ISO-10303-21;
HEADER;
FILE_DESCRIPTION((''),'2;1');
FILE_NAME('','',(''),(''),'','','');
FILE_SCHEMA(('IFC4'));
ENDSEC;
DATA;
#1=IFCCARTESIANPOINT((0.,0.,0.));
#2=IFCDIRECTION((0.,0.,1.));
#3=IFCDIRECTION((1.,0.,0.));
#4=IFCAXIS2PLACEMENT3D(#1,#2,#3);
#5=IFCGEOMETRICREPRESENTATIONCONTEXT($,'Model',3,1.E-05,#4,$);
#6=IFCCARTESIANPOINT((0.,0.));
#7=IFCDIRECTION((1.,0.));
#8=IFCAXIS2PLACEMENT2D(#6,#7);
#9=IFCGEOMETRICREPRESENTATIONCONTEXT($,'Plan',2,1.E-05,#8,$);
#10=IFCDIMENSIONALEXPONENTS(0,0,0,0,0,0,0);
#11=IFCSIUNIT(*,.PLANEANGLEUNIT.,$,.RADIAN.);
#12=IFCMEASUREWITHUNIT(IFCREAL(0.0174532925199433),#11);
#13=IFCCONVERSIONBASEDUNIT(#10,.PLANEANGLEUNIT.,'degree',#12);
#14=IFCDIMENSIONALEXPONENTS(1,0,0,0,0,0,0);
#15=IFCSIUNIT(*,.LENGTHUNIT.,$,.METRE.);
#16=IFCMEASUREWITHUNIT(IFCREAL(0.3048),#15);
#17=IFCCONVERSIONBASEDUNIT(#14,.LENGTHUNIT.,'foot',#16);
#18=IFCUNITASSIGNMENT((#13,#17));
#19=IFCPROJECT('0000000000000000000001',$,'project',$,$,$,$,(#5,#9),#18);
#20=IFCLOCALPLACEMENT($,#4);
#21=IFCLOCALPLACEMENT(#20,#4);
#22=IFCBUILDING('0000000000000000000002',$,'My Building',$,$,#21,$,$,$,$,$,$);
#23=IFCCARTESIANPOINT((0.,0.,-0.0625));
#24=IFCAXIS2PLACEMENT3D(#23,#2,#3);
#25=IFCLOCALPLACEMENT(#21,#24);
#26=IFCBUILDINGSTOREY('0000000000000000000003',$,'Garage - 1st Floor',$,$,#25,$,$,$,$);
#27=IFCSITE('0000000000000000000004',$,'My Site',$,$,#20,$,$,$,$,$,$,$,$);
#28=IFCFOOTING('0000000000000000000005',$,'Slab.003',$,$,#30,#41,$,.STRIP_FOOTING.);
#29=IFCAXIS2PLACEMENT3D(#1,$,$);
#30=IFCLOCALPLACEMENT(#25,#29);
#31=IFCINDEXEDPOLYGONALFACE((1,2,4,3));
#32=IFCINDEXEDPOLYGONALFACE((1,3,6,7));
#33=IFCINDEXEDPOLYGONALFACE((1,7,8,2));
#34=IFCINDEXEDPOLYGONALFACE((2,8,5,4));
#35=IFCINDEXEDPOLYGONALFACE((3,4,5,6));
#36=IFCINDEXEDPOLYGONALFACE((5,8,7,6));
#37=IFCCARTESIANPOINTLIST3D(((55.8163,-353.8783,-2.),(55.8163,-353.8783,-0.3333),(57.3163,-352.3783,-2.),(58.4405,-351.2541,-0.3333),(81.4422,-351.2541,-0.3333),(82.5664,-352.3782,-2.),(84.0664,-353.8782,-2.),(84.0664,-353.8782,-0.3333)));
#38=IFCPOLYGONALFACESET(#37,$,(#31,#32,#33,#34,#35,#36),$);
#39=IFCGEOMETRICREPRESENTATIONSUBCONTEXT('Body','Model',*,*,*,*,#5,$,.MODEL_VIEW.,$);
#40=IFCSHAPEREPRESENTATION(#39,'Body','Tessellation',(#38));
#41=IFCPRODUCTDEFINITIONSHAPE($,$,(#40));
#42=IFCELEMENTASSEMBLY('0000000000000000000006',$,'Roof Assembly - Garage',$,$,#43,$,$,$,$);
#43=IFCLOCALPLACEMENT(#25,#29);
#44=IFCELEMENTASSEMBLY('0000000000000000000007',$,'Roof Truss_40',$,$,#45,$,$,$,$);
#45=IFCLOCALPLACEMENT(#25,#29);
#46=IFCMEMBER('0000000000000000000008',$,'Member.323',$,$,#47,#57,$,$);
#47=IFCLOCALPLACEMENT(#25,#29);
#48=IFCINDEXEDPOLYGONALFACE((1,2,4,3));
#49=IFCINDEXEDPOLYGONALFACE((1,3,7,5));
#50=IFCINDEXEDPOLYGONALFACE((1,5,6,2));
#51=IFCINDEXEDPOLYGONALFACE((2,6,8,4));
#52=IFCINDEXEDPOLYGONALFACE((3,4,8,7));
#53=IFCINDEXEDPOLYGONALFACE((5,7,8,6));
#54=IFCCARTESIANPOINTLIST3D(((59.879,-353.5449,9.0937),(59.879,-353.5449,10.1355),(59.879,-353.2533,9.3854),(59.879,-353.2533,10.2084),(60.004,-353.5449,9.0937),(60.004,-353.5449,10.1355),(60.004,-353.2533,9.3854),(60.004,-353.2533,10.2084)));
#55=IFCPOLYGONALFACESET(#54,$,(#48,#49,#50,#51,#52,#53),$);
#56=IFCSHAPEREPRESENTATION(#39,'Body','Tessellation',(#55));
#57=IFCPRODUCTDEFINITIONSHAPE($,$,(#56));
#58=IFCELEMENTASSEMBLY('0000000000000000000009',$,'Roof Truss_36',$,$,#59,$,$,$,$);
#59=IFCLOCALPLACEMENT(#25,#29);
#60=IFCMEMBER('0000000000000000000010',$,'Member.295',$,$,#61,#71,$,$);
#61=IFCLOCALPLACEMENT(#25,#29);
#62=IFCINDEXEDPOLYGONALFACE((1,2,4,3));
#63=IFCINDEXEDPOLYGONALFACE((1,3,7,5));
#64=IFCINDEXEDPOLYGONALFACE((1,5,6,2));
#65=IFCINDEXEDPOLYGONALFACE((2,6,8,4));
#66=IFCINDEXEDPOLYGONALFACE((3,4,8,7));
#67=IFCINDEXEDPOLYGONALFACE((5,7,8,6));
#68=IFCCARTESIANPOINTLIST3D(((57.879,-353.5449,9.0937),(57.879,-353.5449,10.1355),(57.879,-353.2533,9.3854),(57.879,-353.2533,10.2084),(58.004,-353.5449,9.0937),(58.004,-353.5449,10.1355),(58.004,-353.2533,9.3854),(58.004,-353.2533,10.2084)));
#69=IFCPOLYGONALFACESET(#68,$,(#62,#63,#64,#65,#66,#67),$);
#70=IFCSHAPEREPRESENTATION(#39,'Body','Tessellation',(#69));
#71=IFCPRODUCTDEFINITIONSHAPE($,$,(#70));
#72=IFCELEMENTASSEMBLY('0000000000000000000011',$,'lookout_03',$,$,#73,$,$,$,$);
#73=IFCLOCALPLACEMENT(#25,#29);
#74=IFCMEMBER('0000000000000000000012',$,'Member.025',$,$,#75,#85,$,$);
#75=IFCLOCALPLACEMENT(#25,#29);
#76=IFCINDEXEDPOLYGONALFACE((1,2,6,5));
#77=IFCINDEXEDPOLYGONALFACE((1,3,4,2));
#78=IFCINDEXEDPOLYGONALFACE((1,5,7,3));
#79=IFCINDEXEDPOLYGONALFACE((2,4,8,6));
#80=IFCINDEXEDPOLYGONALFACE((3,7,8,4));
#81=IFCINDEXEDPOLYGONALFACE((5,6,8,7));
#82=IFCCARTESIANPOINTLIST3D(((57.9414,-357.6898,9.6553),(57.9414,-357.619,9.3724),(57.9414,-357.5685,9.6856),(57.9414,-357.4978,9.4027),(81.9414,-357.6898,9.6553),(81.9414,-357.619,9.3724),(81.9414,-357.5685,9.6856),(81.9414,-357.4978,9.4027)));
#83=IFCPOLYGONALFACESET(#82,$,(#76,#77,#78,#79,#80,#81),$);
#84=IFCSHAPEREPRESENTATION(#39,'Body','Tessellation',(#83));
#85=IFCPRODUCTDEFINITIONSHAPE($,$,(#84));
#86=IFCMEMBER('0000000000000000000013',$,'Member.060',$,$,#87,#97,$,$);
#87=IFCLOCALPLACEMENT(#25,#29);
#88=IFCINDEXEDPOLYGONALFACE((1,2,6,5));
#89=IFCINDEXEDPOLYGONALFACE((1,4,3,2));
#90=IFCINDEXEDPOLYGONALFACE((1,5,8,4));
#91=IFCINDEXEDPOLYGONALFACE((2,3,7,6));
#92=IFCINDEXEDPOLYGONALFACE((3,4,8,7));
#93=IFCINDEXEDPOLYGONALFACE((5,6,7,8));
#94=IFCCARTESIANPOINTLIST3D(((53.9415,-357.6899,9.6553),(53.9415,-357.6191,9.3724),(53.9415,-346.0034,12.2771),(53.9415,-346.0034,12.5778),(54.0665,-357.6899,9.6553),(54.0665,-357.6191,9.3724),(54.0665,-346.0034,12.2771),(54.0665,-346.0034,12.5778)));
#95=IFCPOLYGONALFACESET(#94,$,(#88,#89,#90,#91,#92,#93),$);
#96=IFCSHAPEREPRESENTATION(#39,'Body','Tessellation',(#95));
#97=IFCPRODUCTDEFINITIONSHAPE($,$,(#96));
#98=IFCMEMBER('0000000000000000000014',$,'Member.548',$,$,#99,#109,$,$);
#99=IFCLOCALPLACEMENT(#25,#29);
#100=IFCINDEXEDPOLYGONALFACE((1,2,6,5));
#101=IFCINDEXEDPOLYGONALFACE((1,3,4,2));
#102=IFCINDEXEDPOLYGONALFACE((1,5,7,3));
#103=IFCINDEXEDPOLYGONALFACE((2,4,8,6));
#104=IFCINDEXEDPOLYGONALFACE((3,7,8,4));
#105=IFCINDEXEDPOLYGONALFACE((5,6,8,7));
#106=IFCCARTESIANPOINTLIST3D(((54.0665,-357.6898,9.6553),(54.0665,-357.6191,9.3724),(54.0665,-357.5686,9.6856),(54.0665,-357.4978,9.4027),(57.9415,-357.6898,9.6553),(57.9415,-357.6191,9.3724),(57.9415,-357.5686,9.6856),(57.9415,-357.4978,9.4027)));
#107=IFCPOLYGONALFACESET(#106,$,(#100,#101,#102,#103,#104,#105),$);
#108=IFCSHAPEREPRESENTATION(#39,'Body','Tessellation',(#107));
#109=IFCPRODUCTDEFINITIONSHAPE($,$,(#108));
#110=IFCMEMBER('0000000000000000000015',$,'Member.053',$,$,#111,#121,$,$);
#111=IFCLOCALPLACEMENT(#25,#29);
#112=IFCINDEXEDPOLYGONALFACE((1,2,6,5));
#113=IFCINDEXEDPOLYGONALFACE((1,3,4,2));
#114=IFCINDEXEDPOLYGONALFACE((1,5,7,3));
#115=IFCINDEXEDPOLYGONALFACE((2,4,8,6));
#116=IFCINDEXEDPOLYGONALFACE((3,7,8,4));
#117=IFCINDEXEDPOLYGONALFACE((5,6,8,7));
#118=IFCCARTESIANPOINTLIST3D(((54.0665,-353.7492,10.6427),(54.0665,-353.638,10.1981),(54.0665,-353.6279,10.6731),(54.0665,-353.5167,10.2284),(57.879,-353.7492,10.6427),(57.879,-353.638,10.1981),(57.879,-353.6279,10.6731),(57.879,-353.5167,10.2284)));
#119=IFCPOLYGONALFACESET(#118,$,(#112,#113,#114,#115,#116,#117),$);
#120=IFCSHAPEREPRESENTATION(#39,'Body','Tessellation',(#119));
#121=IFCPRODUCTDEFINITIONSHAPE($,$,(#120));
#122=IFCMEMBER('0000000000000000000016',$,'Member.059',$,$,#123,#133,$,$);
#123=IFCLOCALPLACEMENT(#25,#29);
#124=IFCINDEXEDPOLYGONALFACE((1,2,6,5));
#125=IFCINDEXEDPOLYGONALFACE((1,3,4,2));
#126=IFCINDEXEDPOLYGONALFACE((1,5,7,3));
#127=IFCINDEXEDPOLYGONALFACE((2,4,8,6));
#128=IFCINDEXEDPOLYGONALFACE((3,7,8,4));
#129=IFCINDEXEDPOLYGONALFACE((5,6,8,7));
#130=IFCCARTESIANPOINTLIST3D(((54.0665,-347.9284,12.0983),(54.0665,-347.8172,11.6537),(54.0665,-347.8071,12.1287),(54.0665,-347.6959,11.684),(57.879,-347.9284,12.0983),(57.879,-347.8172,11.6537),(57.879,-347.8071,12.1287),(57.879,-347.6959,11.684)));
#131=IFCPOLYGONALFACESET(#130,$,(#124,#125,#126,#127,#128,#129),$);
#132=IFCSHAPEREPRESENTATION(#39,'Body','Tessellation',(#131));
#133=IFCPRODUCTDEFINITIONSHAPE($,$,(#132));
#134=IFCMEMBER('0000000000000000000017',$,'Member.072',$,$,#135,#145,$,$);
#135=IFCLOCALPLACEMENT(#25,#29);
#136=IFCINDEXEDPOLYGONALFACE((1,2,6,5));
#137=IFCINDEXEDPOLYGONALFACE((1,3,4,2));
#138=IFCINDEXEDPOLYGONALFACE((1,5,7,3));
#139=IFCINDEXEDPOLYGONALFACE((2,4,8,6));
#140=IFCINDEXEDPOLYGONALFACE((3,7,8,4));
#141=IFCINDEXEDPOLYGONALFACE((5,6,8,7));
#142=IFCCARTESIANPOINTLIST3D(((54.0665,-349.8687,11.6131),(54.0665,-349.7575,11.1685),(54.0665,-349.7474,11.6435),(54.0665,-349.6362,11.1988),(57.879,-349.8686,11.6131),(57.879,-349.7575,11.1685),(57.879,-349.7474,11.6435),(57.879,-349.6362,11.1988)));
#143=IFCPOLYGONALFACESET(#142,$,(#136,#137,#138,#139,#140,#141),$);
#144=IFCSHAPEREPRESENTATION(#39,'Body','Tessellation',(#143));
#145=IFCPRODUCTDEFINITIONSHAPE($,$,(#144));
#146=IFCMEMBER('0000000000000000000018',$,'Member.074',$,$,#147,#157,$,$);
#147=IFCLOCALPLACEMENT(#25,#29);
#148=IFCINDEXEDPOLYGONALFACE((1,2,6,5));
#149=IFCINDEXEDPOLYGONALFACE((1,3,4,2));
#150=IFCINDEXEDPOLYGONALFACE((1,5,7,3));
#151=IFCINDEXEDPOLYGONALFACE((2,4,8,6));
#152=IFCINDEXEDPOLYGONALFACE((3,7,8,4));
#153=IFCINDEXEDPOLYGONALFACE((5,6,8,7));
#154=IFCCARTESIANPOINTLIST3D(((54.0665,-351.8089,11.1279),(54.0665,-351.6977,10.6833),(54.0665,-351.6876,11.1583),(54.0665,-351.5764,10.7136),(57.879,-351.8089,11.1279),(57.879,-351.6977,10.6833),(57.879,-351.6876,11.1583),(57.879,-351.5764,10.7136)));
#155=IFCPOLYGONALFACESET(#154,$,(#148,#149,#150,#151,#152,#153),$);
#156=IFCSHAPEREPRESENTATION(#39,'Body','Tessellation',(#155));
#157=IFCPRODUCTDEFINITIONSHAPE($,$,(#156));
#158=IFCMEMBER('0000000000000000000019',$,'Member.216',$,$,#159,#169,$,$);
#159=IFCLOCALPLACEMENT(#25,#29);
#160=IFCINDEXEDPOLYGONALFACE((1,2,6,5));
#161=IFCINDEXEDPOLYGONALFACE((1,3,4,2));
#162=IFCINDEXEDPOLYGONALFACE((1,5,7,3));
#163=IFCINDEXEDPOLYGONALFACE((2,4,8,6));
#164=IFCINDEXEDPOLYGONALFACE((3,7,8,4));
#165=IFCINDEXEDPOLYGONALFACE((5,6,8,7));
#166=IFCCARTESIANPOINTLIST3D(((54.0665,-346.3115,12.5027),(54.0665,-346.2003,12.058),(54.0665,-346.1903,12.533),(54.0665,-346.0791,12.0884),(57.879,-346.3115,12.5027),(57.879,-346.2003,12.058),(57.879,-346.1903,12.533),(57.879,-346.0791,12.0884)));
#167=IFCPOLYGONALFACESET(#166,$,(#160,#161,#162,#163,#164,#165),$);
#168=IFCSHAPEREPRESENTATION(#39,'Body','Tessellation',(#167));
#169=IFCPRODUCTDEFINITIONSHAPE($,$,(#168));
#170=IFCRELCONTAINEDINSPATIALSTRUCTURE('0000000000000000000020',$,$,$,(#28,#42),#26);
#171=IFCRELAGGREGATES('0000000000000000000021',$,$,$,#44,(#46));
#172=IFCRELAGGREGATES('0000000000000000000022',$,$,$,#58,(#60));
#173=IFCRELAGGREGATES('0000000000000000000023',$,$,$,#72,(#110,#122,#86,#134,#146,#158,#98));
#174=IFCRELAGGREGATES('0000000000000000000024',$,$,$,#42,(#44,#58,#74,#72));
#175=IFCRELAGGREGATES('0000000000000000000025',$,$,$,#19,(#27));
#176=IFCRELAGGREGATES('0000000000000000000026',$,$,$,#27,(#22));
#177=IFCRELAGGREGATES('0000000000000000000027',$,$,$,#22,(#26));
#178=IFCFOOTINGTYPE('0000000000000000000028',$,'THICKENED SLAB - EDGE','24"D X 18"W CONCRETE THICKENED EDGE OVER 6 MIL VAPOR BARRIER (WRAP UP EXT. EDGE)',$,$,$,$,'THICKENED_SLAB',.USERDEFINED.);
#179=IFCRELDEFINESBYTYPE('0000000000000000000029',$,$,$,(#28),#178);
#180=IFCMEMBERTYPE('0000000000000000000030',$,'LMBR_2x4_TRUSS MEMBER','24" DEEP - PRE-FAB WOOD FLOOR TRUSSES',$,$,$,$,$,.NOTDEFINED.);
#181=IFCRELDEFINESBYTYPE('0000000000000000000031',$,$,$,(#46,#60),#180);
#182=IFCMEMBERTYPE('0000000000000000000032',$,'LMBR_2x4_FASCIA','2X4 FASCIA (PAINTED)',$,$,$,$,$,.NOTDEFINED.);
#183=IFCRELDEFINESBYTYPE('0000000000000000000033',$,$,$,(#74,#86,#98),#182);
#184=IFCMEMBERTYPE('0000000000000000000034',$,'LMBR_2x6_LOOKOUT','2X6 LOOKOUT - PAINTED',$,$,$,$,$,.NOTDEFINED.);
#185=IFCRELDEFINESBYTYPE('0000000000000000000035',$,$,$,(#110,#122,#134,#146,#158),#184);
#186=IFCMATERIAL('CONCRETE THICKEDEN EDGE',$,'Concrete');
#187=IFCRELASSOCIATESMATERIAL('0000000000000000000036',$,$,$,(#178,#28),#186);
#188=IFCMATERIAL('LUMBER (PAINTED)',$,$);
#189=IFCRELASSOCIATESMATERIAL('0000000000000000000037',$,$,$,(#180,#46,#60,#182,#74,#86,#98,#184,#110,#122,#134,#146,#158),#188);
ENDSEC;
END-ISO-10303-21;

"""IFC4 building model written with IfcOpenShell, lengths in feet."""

from ifc_helpers import new_model, entity, si_unit, converted_unit, frame, origin_with_axes, origin_2d_with_axis, place, context, subcontext, project, spatial, line, indexed_curve, outline, extrude, clip, halfspace, material, material_profile, profile_set, profile_usage, type_object, element, aggregate, save


model = new_model("IFC4")

# Units and contexts
model_context = context("Model", 3, precision=1e-05, world=origin_with_axes())
plan_context = context("Plan", 2, precision=1e-05, world=origin_2d_with_axis())
body_context = subcontext(model_context, "Body", "Model", "MODEL_VIEW")
ifc_project = project(units=[converted_unit("PLANEANGLEUNIT", "degree", entity("IfcReal", 0.0174532925199433), si_unit("PLANEANGLEUNIT", "RADIAN"), dimensions=[0, 0, 0, 0, 0, 0, 0]), converted_unit("LENGTHUNIT", "foot", entity("IfcReal", 0.3048), si_unit("LENGTHUNIT", "METRE"), dimensions=[1, 0, 0, 0, 0, 0, 0])], contexts=[model_context, plan_context])

# Site, building, storey
site_placement = place(None, origin_with_axes())
site = spatial("IfcSite", under=ifc_project, at=site_placement, Name="My Site")
building_placement = place(site_placement, origin_with_axes())
building = spatial("IfcBuilding", under=site, at=building_placement, Name="My Building")
storey_placement = place(building_placement, frame((0.0, 0.0, -0.0625), z_axis=(0.0, 0.0, 1.0), x_axis=(1.0, 0.0, 0.0)))
storey = spatial("IfcBuildingStorey", under=building, at=storey_placement, Name="Garage - 1st Floor")

# Footing
ifc_material_1 = material(Name="CONCRETE THICKEDEN EDGE", Category="Concrete")
ifc_material_profile_1 = material_profile(ifc_material_1, outline(indexed_curve([(0.0, 1.6667), (0.0, 0.0), (2.6242, 1.6667), (1.5, 0.0)], segments=[line(4, 2), line(2, 1), line(1, 3), line(3, 4)], self_intersect=False)))
ifc_profile_set_1 = profile_set([ifc_material_profile_1])
ifc_profile_usage_1 = profile_usage(ifc_profile_set_1, cardinal=5)
footing_type = type_object("IfcFootingType", Name="THICKENED SLAB - EDGE", Description="24\"D X 18\"W CONCRETE THICKENED EDGE OVER 6 MIL VAPOR BARRIER (WRAP UP EXT. EDGE)", ElementType="THICKENED_SLAB", PredefinedType="USERDEFINED", material=ifc_profile_set_1)
footing_placement = place(storey_placement, frame((55.8163, -353.8783, -2.0), z_axis=(1.0, 0.000001, 0.0), x_axis=(-0.000001, 1.0, 0.0)))
element("IfcFooting", 1, at=footing_placement, inside=storey, type_object=footing_type, material=ifc_profile_usage_1, Name="Slab.003", PredefinedType="STRIP_FOOTING", context=body_context, shape_type="Clipping", body=[
    clip(clip(extrude(outline(indexed_curve([(0.0, 1.6667), (0.0, 0.0), (2.6242, 1.6667), (1.5, 0.0)], segments=[line(4, 2), line(2, 1), line(1, 3), line(3, 4)], self_intersect=False)), origin_with_axes(), (0.0, 0.0, 1.0), 28.2501), halfspace(frame((0.0, 2.0625, 0.0), z_axis=(0.707106, 0.0, -0.707107), x_axis=(0.0, -1.0, 0.0)), False)), halfspace(frame((0.0, 2.0625, 28.2501), z_axis=(0.707106, 0.0, 0.707107), x_axis=(0.0, -1.0, 0.0)), False)),
])

# Element assemblies, members
assembly_1_placement = place(storey_placement, frame((0.0, 0.0, 0.125), z_axis=(0.0, 0.0, 1.0), x_axis=(1.0, 0.0, 0.0)))
assembly_1 = element("IfcElementAssembly", 2, at=assembly_1_placement, inside=storey, Name="Roof Assembly - Garage")
assembly_2_placement = place(assembly_1_placement, frame((59.9415, -346.0033, 12.5192), z_axis=(0.0, 0.0, 1.0), x_axis=(0.0, 1.0, 0.0)))
assembly_2 = element("IfcElementAssembly", 3, at=assembly_2_placement, Name="Roof Truss_40")
ifc_material_2 = material(Name="LUMBER (PAINTED)")
ifc_material_profile_2 = material_profile(ifc_material_2, outline(indexed_curve([(-0.0625, -0.1458), (0.0625, -0.1458), (0.0625, 0.1458), (-0.0625, 0.1458), (-0.0625, -0.1458)])))
ifc_profile_set_2 = profile_set([ifc_material_profile_2])
ifc_profile_usage_2 = profile_usage(ifc_profile_set_2)
member_type_1 = type_object("IfcMemberType", Name="LMBR_2x4_TRUSS MEMBER", Description="24\" DEEP - PRE-FAB WOOD FLOOR TRUSSES", PredefinedType="NOTDEFINED", material=ifc_profile_set_2)
member_1_placement = place(assembly_2_placement, frame((-7.3958, 0.0, -2.1806), z_axis=(0.0, 0.0, -1.0), x_axis=(0.0, 1.0, 0.0)))
member_1 = element("IfcMember", 4, at=member_1_placement, type_object=member_type_1, material=ifc_profile_usage_2, Name="Member.323", context=body_context, shape_type="Clipping", body=[
    clip(clip(extrude(outline(indexed_curve([(-0.0625, -0.1458), (0.0625, -0.1458), (0.0625, 0.1458), (-0.0625, 0.1458), (-0.0625, -0.1458)])), origin_with_axes(), (0.0, 0.0, 1.0), 1.3698), halfspace(frame((0.0, 7.5424, -1.5944), z_axis=(0.0, -0.242599, -0.970127), x_axis=(-1.0, 0.000001, 0.0)), False)), halfspace(frame((397.5032, -0.1458, 1.3698), z_axis=(0.0, 0.707107, 0.707107), x_axis=(1.0, 0.0, 0.0)), False)),
])
assembly_3_placement = place(assembly_1_placement, frame((57.9415, -346.0033, 12.5192), z_axis=(0.0, 0.0, 1.0), x_axis=(0.0, 1.0, 0.0)))
assembly_3 = element("IfcElementAssembly", 5, at=assembly_3_placement, Name="Roof Truss_36")
ifc_profile_usage_3 = profile_usage(ifc_profile_set_2)
member_2_placement = place(assembly_3_placement, frame((-7.3958, 0.0, -2.1806), z_axis=(0.0, 0.0, -1.0), x_axis=(0.0, 1.0, 0.0)))
member_2 = element("IfcMember", 6, at=member_2_placement, type_object=member_type_1, material=ifc_profile_usage_3, Name="Member.295", context=body_context, shape_type="Clipping", body=[
    clip(clip(extrude(outline(indexed_curve([(-0.0625, -0.1458), (0.0625, -0.1458), (0.0625, 0.1458), (-0.0625, 0.1458), (-0.0625, -0.1458)])), origin_with_axes(), (0.0, 0.0, 1.0), 1.3698), halfspace(frame((0.0, 7.5424, -1.5944), z_axis=(0.0, -0.242599, -0.970127), x_axis=(-1.0, 0.000001, 0.0)), False)), halfspace(frame((397.5032, -0.1458, 1.3698), z_axis=(0.0, 0.707107, 0.707107), x_axis=(1.0, 0.0, 0.0)), False)),
])
assembly_4_placement = place(assembly_1_placement, frame((57.9415, -346.0033, 12.5192), z_axis=(0.0, 0.0, 1.0), x_axis=(-0.000001, 1.0, 0.0)))
assembly_4 = element("IfcElementAssembly", 7, at=assembly_4_placement, Name="lookout_03")
aggregate(assembly_2, [member_1])
aggregate(assembly_3, [member_2])
ifc_material_profile_3 = material_profile(ifc_material_2, outline(indexed_curve([(-0.0625, -0.1458), (0.0625, -0.1458), (0.0625, 0.1458), (-0.0625, 0.1458), (-0.0625, -0.1458)])))
ifc_profile_set_3 = profile_set([ifc_material_profile_3])
ifc_profile_usage_4 = profile_usage(ifc_profile_set_3)
member_type_2 = type_object("IfcMemberType", Name="LMBR_2x4_FASCIA", Description="2X4 FASCIA (PAINTED)", PredefinedType="NOTDEFINED", material=ifc_profile_set_3)
member_3_placement = place(assembly_1_placement, frame((57.9414, -357.5938, 9.404), z_axis=(1.0, 0.0, 0.0), x_axis=(-0.000001, 0.970127, 0.242599)))
member_3 = element("IfcMember", 8, at=member_3_placement, type_object=member_type_2, material=ifc_profile_usage_4, Name="Member.025", context=body_context, shape_type="SweptSolid", body=[
    extrude(outline(indexed_curve([(-0.0625, -0.1458), (0.0625, -0.1458), (0.0625, 0.1458), (-0.0625, 0.1458), (-0.0625, -0.1458)])), origin_with_axes(), (0.0, 0.0, 1.0), 24.0),
])
ifc_profile_usage_5 = profile_usage(ifc_profile_set_3)
member_4_placement = place(assembly_4_placement, frame((-11.6512, 3.9375, -3.1303), z_axis=(0.970127, 0.0, 0.242599), x_axis=(0.0, 1.0, 0.0)))
member_4 = element("IfcMember", 9, at=member_4_placement, type_object=member_type_2, material=ifc_profile_usage_5, Name="Member.060", context=body_context, shape_type="Clipping", body=[
    clip(extrude(outline(indexed_curve([(-0.0625, -0.1458), (0.0625, -0.1458), (0.0625, 0.1458), (-0.0625, 0.1458), (-0.0625, -0.1458)])), origin_with_axes(), (0.0, 0.0, 1.0), 12.6114), halfspace(frame((-85.8788, 0.1458, 12.0464), z_axis=(0.0, -0.242599, 0.970127), x_axis=(-1.0, -0.000001, 0.0)), False)),
])
ifc_profile_usage_6 = profile_usage(ifc_profile_set_3)
member_5_placement = place(assembly_4_placement, frame((-11.5905, 0.0, -3.1152), z_axis=(0.0, 1.0, 0.0), x_axis=(-0.970127, 0.0, -0.242599)))
member_5 = element("IfcMember", 10, at=member_5_placement, type_object=member_type_2, material=ifc_profile_usage_6, Name="Member.548", context=body_context, shape_type="SweptSolid", body=[
    extrude(outline(indexed_curve([(-0.0625, -0.1458), (0.0625, -0.1458), (0.0625, 0.1458), (-0.0625, 0.1458), (-0.0625, -0.1458)])), origin_with_axes(), (0.0, 0.0, 1.0), 3.875),
])
ifc_material_profile_4 = material_profile(ifc_material_2, outline(indexed_curve([(-0.0625, 0.2292), (0.0625, 0.2292), (0.0625, -0.2292), (-0.0625, -0.2292), (-0.0625, 0.2292)])))
ifc_profile_set_4 = profile_set([ifc_material_profile_4])
ifc_profile_usage_7 = profile_usage(ifc_profile_set_4)
member_type_3 = type_object("IfcMemberType", Name="LMBR_2x6_LOOKOUT", Description="2X6 LOOKOUT - PAINTED", PredefinedType="NOTDEFINED", material=ifc_profile_set_4)
member_6_placement = place(assembly_4_placement, frame((-7.6296, 0.0625, -2.2086), z_axis=(0.0, 1.0, 0.0), x_axis=(-0.970127, 0.0, -0.242599)))
member_6 = element("IfcMember", 11, at=member_6_placement, type_object=member_type_3, material=ifc_profile_usage_7, Name="Member.053", context=body_context, shape_type="SweptSolid", body=[
    extrude(outline(indexed_curve([(-0.0625, 0.2292), (0.0625, 0.2292), (0.0625, -0.2292), (-0.0625, -0.2292), (-0.0625, 0.2292)])), origin_with_axes(), (0.0, 0.0, 1.0), 3.8125),
])
ifc_profile_usage_8 = profile_usage(ifc_profile_set_4)
member_7_placement = place(assembly_4_placement, frame((-1.8089, 0.0625, -0.753), z_axis=(0.0, 1.0, 0.0), x_axis=(-0.970127, 0.0, -0.242599)))
member_7 = element("IfcMember", 12, at=member_7_placement, type_object=member_type_3, material=ifc_profile_usage_8, Name="Member.059", context=body_context, shape_type="SweptSolid", body=[
    extrude(outline(indexed_curve([(-0.0625, 0.2292), (0.0625, 0.2292), (0.0625, -0.2292), (-0.0625, -0.2292), (-0.0625, 0.2292)])), origin_with_axes(), (0.0, 0.0, 1.0), 3.8125),
])
ifc_profile_usage_9 = profile_usage(ifc_profile_set_4)
member_8_placement = place(assembly_4_placement, frame((-3.7491, 0.0625, -1.2382), z_axis=(0.0, 1.0, 0.0), x_axis=(-0.970127, 0.0, -0.242599)))
member_8 = element("IfcMember", 13, at=member_8_placement, type_object=member_type_3, material=ifc_profile_usage_9, Name="Member.072", context=body_context, shape_type="SweptSolid", body=[
    extrude(outline(indexed_curve([(-0.0625, 0.2292), (0.0625, 0.2292), (0.0625, -0.2292), (-0.0625, -0.2292), (-0.0625, 0.2292)])), origin_with_axes(), (0.0, 0.0, 1.0), 3.8125),
])
ifc_profile_usage_10 = profile_usage(ifc_profile_set_4)
member_9_placement = place(assembly_4_placement, frame((-5.6894, 0.0625, -1.7234), z_axis=(0.0, 1.0, 0.0), x_axis=(-0.970127, 0.0, -0.242599)))
member_9 = element("IfcMember", 14, at=member_9_placement, type_object=member_type_3, material=ifc_profile_usage_10, Name="Member.074", context=body_context, shape_type="SweptSolid", body=[
    extrude(outline(indexed_curve([(-0.0625, 0.2292), (0.0625, 0.2292), (0.0625, -0.2292), (-0.0625, -0.2292), (-0.0625, 0.2292)])), origin_with_axes(), (0.0, 0.0, 1.0), 3.8125),
])
ifc_profile_usage_11 = profile_usage(ifc_profile_set_4)
member_10_placement = place(assembly_4_placement, frame((-0.192, 0.0625, -0.3487), z_axis=(0.0, 1.0, 0.0), x_axis=(-0.970127, 0.0, -0.242599)))
member_10 = element("IfcMember", 15, at=member_10_placement, type_object=member_type_3, material=ifc_profile_usage_11, Name="Member.216", context=body_context, shape_type="SweptSolid", body=[
    extrude(outline(indexed_curve([(-0.0625, 0.2292), (0.0625, 0.2292), (0.0625, -0.2292), (-0.0625, -0.2292), (-0.0625, 0.2292)])), origin_with_axes(), (0.0, 0.0, 1.0), 3.8125),
])
aggregate(assembly_4, [member_6, member_7, member_4, member_8, member_9, member_10, member_5])

aggregate(assembly_1, [assembly_2, assembly_3, member_3, assembly_4])

save(model, "model.ifc")
